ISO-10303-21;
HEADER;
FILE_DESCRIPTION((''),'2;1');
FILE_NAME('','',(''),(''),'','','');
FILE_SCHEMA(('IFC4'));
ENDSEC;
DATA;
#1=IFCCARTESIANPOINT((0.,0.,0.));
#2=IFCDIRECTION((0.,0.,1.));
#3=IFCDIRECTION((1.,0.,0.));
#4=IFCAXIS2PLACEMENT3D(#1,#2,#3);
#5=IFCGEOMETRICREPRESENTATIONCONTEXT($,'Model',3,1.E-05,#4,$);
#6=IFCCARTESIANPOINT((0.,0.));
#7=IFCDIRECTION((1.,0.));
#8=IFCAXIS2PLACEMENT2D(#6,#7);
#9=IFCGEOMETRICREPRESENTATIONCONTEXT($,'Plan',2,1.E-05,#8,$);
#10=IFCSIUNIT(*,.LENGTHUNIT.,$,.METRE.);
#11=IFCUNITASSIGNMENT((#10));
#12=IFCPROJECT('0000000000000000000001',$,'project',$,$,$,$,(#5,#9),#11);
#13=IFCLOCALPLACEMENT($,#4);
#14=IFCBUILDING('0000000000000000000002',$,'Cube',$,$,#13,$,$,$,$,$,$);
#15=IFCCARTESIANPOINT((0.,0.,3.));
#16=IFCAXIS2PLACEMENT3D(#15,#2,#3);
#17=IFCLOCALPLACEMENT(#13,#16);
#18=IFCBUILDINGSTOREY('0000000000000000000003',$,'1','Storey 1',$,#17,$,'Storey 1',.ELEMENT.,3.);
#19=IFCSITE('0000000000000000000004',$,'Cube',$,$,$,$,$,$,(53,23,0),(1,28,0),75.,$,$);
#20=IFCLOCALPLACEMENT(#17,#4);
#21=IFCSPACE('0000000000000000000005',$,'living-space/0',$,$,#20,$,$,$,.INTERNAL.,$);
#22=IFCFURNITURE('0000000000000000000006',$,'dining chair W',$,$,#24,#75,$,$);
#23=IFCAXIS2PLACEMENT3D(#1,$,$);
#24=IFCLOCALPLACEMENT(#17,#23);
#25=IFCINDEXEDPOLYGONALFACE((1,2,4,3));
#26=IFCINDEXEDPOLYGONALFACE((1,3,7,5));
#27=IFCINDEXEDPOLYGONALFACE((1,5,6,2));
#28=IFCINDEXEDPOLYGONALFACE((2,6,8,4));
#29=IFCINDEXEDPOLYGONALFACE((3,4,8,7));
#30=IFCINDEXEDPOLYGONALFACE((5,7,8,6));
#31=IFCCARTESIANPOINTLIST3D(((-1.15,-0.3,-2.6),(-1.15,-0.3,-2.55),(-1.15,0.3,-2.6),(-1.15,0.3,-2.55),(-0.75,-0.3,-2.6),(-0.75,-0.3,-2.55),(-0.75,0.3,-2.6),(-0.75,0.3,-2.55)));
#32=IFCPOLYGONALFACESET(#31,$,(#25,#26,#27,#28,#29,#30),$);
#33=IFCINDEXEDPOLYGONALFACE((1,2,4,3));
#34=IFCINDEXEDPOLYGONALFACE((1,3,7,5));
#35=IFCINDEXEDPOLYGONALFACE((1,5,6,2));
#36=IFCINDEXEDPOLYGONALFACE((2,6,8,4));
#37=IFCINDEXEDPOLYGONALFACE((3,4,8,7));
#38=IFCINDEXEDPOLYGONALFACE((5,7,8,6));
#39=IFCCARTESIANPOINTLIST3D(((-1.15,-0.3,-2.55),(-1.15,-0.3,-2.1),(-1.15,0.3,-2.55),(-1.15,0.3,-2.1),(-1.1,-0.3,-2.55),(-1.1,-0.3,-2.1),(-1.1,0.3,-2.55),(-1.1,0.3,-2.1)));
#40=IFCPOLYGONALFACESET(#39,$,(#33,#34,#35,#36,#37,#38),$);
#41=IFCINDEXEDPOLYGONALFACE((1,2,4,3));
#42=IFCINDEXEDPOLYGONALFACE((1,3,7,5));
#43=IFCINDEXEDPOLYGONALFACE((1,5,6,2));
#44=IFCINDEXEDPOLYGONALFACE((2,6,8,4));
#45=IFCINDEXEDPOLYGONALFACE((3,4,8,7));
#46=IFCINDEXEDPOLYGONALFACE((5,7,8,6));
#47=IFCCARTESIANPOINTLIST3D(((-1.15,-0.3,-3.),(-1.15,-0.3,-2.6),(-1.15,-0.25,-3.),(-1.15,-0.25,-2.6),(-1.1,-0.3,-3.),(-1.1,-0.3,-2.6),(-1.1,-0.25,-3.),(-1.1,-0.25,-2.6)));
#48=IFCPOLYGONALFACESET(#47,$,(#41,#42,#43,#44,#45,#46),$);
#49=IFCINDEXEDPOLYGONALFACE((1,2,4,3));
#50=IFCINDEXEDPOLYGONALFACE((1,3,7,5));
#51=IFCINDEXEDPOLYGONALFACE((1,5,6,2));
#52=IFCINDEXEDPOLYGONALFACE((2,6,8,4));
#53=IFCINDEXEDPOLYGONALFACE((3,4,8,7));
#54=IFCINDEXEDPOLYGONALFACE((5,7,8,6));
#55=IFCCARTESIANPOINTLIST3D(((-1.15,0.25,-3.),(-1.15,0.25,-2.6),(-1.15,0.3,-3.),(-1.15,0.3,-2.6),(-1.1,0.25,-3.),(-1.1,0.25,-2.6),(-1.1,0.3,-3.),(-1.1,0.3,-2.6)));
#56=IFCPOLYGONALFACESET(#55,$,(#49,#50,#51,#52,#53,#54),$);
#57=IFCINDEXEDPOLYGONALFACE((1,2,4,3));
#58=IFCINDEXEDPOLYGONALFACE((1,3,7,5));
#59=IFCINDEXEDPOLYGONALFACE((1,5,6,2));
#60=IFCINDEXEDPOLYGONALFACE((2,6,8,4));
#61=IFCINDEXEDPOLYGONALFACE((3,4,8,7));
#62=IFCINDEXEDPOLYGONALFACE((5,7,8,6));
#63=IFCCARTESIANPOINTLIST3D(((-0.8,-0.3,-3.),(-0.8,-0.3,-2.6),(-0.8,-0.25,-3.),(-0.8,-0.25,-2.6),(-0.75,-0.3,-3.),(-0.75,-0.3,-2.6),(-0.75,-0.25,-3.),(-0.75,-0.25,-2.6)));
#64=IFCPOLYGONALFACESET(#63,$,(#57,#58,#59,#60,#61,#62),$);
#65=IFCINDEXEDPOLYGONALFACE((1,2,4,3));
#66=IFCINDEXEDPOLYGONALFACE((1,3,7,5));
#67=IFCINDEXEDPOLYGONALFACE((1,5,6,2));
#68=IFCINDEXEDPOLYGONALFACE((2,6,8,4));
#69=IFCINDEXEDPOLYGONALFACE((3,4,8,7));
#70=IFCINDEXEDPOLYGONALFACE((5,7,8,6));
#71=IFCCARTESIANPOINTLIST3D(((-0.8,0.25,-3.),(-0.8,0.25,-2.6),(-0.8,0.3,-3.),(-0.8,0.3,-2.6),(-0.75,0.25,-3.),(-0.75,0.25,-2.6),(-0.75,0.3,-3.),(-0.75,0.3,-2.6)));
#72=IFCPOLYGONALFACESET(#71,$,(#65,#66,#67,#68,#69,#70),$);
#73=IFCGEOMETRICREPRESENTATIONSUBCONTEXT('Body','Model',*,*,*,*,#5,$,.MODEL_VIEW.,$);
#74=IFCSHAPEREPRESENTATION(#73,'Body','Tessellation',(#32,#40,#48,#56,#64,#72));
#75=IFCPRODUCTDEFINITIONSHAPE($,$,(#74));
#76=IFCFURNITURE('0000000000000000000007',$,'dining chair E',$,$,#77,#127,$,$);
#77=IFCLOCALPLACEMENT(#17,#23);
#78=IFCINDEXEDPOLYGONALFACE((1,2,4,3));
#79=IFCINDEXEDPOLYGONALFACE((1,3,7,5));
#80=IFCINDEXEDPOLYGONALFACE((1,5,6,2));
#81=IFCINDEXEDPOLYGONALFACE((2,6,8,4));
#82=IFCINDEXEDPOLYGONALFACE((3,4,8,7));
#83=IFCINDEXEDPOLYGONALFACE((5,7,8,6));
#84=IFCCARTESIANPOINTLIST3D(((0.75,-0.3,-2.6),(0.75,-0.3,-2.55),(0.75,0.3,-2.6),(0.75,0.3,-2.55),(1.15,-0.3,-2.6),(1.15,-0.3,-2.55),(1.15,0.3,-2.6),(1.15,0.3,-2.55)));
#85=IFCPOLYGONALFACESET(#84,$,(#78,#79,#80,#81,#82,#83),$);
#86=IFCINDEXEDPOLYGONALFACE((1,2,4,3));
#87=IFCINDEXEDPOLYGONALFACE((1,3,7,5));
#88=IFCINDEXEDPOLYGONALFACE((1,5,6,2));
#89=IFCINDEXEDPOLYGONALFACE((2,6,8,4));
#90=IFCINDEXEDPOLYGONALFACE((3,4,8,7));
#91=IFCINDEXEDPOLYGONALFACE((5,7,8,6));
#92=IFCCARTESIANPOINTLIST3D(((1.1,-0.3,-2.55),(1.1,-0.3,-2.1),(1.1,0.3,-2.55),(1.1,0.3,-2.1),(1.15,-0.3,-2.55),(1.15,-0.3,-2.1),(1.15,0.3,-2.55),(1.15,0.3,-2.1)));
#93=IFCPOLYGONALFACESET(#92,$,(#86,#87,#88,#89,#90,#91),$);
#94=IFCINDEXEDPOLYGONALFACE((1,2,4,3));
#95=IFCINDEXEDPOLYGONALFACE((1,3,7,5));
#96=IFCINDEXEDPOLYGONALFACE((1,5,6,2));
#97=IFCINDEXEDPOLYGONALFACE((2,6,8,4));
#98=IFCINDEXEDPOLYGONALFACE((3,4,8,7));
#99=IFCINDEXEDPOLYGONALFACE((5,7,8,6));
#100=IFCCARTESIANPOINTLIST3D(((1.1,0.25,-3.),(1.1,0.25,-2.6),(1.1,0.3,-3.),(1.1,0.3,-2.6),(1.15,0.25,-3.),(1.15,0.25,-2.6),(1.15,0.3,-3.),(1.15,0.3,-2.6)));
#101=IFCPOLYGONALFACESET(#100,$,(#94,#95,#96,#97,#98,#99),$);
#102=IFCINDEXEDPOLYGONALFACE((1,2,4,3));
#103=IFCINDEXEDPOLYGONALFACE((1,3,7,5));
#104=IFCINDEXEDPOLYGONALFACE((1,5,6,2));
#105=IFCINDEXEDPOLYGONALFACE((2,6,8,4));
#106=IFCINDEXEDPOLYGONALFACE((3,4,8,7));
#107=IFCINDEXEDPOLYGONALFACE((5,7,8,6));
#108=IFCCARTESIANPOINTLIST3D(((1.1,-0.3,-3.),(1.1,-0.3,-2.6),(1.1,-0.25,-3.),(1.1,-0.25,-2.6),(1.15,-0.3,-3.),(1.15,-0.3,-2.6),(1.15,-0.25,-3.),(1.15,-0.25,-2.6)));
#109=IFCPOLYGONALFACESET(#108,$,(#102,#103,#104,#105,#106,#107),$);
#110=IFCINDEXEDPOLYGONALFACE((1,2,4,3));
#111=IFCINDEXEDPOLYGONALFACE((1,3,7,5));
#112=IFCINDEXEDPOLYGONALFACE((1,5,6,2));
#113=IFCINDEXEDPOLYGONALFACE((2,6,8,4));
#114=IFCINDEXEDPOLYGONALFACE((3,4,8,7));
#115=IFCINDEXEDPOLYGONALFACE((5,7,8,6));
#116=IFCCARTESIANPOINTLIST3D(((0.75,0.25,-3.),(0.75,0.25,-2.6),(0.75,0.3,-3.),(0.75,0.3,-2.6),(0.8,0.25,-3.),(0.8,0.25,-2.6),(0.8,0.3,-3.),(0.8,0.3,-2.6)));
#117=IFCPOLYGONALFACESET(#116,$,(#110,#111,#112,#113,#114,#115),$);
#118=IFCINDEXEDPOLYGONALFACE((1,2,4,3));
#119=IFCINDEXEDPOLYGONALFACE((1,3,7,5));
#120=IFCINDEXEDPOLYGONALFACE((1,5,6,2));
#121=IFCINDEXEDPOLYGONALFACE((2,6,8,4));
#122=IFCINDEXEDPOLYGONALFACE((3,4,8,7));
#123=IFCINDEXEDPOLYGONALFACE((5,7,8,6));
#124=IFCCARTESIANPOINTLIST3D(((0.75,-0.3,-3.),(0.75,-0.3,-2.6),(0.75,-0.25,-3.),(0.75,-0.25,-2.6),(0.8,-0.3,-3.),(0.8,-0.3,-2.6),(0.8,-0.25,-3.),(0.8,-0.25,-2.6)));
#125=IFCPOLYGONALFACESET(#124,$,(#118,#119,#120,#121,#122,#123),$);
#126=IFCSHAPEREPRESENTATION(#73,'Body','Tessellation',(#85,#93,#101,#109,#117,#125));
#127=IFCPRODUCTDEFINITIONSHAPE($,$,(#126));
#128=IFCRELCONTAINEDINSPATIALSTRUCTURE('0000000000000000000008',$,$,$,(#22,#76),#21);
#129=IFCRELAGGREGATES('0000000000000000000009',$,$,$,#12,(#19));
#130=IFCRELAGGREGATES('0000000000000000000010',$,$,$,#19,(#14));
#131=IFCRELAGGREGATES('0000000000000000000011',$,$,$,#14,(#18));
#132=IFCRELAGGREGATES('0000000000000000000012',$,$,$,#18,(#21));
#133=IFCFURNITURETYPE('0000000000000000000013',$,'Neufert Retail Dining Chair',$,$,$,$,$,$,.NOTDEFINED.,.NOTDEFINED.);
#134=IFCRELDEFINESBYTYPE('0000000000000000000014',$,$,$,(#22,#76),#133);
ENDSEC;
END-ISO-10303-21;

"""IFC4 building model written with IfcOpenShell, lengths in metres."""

from ifc_helpers import new_model, entity, si_unit, frame, origin_with_axes, origin_2d_with_axis, place, context, subcontext, project, spatial, line, indexed_curve, outline, extrude, shape, source, transform, mapped, type_object, type_shapes, element, save


model = new_model("IFC4")

# Units and contexts
model_context = context("Model", 3, precision=1e-05, world=origin_with_axes())
plan_context = context("Plan", 2, precision=1e-05, world=origin_2d_with_axis())
body_context_1 = subcontext(model_context, "Body", "Model", "MODEL_VIEW")
body_context_2 = subcontext(plan_context, "Body", "Plan", "PLAN_VIEW")
ifc_project = project(units=[si_unit("LENGTHUNIT", "METRE")], contexts=[model_context, plan_context])

# Site, building, storey
site = spatial("IfcSite", under=ifc_project, Name="Cube", RefLatitude=(53, 23, 0), RefLongitude=(1, 28, 0), RefElevation=75.0)
building_placement = place(None, origin_with_axes())
building = spatial("IfcBuilding", under=site, at=building_placement, Name="Cube")
storey_placement = place(building_placement, frame((0.0, 0.0, 3.0), z_axis=(0.0, 0.0, 1.0), x_axis=(1.0, 0.0, 0.0)))
storey = spatial("IfcBuildingStorey", under=building, at=storey_placement, Name="1", Description="Storey 1", LongName="Storey 1", CompositionType="ELEMENT", Elevation=3.0)

# Shared definitions
space_placement = place(storey_placement, origin_with_axes())
space = spatial("IfcSpace", under=storey, at=space_placement, Name="living-space/0", PredefinedType="INTERNAL")

# Furniture
furniture_type_1 = type_object("IfcFurnitureType", Name="Neufert Retail Dining Chair", AssemblyPlace="NOTDEFINED", PredefinedType="NOTDEFINED")
shared_shape_1 = source(origin_with_axes(), body_context_1, "Body", "SweptSolid", [
    extrude(outline(indexed_curve([(-0.3, 0.0), (0.3, 0.0), (0.3, -0.4), (-0.3, -0.4)], segments=[line(1, 2, 3, 4, 1)])), frame((0.0, 0.0, 0.45), z_axis=(0.0, 0.0, 1.0), x_axis=(1.0, 0.0, 0.0)), (0.0, 0.0, -1.0), 0.05),
    extrude(outline(indexed_curve([(-0.3, 0.0), (0.3, 0.0), (0.3, -0.05), (-0.3, -0.05)], segments=[line(1, 2, 3, 4, 1)])), frame((0.0, 0.0, 0.9), z_axis=(0.0, 0.0, 1.0), x_axis=(1.0, 0.0, 0.0)), (0.0, 0.0, -1.0), 0.45),
    extrude(outline(indexed_curve([(-0.3, 0.0), (-0.25, 0.0), (-0.25, -0.05), (-0.3, -0.05)], segments=[line(1, 2, 3, 4, 1)])), origin_with_axes(), (0.0, 0.0, 1.0), 0.4),
    extrude(outline(indexed_curve([(0.3, 0.0), (0.25, 0.0), (0.25, -0.05), (0.3, -0.05)], segments=[line(1, 2, 3, 4, 1)])), origin_with_axes(), (0.0, 0.0, 1.0), 0.4),
    extrude(outline(indexed_curve([(-0.3, -0.4), (-0.25, -0.4), (-0.25, -0.35), (-0.3, -0.35)], segments=[line(1, 2, 3, 4, 1)])), origin_with_axes(), (0.0, 0.0, 1.0), 0.4),
    extrude(outline(indexed_curve([(0.3, -0.4), (0.25, -0.4), (0.25, -0.35), (0.3, -0.35)], segments=[line(1, 2, 3, 4, 1)])), origin_with_axes(), (0.0, 0.0, 1.0), 0.4),
])
shared_shape_2 = source(origin_with_axes(), body_context_2, "Body", "Curve2D", [
    entity("IfcIndexedPolyCurve", entity("IfcCartesianPointList2D", [[-0.3, -0.4], [0.3, -0.4]])),
    entity("IfcIndexedPolyCurve", entity("IfcCartesianPointList2D", [[-0.3, -0.4], [-0.3, -0.3], [-0.2121, -0.0879], [0.0, 0.0], [0.2121, -0.0879], [0.3, -0.3], [0.3, -0.4]]), [entity("IfcLineIndex", [1, 2]), entity("IfcArcIndex", [2, 3, 4]), entity("IfcArcIndex", [4, 5, 6]), entity("IfcLineIndex", [6, 7])]),
    entity("IfcIndexedPolyCurve", entity("IfcCartesianPointList2D", [[-0.26, -0.4], [-0.26, -0.3], [-0.1838, -0.1162], [0.0, -0.04], [0.1838, -0.1162], [0.26, -0.3], [0.26, -0.4]]), [entity("IfcLineIndex", [1, 2]), entity("IfcArcIndex", [2, 3, 4]), entity("IfcArcIndex", [4, 5, 6]), entity("IfcLineIndex", [6, 7])]),
])
type_shapes(furniture_type_1, [shared_shape_1, shared_shape_2])
for number, where, z_axis, x_axis, name in (
    (1, (-1.15, 0.0, -3.0), (0.0, 0.0, 1.0), (0.0, 1.0, 0.0), "dining chair W"),
    (2, (1.15, 0.0, -3.0), (0.0, 0.0, 1.0), (0.0, -1.0, 0.0), "dining chair E"),
):
    element("IfcFurniture", number, at=place(space_placement, frame(where, z_axis=z_axis, x_axis=x_axis)), inside=space, type_object=furniture_type_1, Name=name, shapes=[
        shape(body_context_1, "Body", "MappedRepresentation", [mapped(shared_shape_1, transform((0.0, 0.0, 0.0), x_axis=(1.0, 0.0, 0.0), y_axis=(0.0, 1.0, 0.0), z_axis=(0.0, 0.0, 1.0), scale=1.0))]),
        shape(body_context_2, "Body", "MappedRepresentation", [mapped(shared_shape_2, transform((0.0, 0.0, 0.0), x_axis=(1.0, 0.0, 0.0), y_axis=(0.0, 1.0, 0.0), z_axis=(0.0, 0.0, 1.0), scale=1.0))]),
    ])

save(model, "model.ifc")
